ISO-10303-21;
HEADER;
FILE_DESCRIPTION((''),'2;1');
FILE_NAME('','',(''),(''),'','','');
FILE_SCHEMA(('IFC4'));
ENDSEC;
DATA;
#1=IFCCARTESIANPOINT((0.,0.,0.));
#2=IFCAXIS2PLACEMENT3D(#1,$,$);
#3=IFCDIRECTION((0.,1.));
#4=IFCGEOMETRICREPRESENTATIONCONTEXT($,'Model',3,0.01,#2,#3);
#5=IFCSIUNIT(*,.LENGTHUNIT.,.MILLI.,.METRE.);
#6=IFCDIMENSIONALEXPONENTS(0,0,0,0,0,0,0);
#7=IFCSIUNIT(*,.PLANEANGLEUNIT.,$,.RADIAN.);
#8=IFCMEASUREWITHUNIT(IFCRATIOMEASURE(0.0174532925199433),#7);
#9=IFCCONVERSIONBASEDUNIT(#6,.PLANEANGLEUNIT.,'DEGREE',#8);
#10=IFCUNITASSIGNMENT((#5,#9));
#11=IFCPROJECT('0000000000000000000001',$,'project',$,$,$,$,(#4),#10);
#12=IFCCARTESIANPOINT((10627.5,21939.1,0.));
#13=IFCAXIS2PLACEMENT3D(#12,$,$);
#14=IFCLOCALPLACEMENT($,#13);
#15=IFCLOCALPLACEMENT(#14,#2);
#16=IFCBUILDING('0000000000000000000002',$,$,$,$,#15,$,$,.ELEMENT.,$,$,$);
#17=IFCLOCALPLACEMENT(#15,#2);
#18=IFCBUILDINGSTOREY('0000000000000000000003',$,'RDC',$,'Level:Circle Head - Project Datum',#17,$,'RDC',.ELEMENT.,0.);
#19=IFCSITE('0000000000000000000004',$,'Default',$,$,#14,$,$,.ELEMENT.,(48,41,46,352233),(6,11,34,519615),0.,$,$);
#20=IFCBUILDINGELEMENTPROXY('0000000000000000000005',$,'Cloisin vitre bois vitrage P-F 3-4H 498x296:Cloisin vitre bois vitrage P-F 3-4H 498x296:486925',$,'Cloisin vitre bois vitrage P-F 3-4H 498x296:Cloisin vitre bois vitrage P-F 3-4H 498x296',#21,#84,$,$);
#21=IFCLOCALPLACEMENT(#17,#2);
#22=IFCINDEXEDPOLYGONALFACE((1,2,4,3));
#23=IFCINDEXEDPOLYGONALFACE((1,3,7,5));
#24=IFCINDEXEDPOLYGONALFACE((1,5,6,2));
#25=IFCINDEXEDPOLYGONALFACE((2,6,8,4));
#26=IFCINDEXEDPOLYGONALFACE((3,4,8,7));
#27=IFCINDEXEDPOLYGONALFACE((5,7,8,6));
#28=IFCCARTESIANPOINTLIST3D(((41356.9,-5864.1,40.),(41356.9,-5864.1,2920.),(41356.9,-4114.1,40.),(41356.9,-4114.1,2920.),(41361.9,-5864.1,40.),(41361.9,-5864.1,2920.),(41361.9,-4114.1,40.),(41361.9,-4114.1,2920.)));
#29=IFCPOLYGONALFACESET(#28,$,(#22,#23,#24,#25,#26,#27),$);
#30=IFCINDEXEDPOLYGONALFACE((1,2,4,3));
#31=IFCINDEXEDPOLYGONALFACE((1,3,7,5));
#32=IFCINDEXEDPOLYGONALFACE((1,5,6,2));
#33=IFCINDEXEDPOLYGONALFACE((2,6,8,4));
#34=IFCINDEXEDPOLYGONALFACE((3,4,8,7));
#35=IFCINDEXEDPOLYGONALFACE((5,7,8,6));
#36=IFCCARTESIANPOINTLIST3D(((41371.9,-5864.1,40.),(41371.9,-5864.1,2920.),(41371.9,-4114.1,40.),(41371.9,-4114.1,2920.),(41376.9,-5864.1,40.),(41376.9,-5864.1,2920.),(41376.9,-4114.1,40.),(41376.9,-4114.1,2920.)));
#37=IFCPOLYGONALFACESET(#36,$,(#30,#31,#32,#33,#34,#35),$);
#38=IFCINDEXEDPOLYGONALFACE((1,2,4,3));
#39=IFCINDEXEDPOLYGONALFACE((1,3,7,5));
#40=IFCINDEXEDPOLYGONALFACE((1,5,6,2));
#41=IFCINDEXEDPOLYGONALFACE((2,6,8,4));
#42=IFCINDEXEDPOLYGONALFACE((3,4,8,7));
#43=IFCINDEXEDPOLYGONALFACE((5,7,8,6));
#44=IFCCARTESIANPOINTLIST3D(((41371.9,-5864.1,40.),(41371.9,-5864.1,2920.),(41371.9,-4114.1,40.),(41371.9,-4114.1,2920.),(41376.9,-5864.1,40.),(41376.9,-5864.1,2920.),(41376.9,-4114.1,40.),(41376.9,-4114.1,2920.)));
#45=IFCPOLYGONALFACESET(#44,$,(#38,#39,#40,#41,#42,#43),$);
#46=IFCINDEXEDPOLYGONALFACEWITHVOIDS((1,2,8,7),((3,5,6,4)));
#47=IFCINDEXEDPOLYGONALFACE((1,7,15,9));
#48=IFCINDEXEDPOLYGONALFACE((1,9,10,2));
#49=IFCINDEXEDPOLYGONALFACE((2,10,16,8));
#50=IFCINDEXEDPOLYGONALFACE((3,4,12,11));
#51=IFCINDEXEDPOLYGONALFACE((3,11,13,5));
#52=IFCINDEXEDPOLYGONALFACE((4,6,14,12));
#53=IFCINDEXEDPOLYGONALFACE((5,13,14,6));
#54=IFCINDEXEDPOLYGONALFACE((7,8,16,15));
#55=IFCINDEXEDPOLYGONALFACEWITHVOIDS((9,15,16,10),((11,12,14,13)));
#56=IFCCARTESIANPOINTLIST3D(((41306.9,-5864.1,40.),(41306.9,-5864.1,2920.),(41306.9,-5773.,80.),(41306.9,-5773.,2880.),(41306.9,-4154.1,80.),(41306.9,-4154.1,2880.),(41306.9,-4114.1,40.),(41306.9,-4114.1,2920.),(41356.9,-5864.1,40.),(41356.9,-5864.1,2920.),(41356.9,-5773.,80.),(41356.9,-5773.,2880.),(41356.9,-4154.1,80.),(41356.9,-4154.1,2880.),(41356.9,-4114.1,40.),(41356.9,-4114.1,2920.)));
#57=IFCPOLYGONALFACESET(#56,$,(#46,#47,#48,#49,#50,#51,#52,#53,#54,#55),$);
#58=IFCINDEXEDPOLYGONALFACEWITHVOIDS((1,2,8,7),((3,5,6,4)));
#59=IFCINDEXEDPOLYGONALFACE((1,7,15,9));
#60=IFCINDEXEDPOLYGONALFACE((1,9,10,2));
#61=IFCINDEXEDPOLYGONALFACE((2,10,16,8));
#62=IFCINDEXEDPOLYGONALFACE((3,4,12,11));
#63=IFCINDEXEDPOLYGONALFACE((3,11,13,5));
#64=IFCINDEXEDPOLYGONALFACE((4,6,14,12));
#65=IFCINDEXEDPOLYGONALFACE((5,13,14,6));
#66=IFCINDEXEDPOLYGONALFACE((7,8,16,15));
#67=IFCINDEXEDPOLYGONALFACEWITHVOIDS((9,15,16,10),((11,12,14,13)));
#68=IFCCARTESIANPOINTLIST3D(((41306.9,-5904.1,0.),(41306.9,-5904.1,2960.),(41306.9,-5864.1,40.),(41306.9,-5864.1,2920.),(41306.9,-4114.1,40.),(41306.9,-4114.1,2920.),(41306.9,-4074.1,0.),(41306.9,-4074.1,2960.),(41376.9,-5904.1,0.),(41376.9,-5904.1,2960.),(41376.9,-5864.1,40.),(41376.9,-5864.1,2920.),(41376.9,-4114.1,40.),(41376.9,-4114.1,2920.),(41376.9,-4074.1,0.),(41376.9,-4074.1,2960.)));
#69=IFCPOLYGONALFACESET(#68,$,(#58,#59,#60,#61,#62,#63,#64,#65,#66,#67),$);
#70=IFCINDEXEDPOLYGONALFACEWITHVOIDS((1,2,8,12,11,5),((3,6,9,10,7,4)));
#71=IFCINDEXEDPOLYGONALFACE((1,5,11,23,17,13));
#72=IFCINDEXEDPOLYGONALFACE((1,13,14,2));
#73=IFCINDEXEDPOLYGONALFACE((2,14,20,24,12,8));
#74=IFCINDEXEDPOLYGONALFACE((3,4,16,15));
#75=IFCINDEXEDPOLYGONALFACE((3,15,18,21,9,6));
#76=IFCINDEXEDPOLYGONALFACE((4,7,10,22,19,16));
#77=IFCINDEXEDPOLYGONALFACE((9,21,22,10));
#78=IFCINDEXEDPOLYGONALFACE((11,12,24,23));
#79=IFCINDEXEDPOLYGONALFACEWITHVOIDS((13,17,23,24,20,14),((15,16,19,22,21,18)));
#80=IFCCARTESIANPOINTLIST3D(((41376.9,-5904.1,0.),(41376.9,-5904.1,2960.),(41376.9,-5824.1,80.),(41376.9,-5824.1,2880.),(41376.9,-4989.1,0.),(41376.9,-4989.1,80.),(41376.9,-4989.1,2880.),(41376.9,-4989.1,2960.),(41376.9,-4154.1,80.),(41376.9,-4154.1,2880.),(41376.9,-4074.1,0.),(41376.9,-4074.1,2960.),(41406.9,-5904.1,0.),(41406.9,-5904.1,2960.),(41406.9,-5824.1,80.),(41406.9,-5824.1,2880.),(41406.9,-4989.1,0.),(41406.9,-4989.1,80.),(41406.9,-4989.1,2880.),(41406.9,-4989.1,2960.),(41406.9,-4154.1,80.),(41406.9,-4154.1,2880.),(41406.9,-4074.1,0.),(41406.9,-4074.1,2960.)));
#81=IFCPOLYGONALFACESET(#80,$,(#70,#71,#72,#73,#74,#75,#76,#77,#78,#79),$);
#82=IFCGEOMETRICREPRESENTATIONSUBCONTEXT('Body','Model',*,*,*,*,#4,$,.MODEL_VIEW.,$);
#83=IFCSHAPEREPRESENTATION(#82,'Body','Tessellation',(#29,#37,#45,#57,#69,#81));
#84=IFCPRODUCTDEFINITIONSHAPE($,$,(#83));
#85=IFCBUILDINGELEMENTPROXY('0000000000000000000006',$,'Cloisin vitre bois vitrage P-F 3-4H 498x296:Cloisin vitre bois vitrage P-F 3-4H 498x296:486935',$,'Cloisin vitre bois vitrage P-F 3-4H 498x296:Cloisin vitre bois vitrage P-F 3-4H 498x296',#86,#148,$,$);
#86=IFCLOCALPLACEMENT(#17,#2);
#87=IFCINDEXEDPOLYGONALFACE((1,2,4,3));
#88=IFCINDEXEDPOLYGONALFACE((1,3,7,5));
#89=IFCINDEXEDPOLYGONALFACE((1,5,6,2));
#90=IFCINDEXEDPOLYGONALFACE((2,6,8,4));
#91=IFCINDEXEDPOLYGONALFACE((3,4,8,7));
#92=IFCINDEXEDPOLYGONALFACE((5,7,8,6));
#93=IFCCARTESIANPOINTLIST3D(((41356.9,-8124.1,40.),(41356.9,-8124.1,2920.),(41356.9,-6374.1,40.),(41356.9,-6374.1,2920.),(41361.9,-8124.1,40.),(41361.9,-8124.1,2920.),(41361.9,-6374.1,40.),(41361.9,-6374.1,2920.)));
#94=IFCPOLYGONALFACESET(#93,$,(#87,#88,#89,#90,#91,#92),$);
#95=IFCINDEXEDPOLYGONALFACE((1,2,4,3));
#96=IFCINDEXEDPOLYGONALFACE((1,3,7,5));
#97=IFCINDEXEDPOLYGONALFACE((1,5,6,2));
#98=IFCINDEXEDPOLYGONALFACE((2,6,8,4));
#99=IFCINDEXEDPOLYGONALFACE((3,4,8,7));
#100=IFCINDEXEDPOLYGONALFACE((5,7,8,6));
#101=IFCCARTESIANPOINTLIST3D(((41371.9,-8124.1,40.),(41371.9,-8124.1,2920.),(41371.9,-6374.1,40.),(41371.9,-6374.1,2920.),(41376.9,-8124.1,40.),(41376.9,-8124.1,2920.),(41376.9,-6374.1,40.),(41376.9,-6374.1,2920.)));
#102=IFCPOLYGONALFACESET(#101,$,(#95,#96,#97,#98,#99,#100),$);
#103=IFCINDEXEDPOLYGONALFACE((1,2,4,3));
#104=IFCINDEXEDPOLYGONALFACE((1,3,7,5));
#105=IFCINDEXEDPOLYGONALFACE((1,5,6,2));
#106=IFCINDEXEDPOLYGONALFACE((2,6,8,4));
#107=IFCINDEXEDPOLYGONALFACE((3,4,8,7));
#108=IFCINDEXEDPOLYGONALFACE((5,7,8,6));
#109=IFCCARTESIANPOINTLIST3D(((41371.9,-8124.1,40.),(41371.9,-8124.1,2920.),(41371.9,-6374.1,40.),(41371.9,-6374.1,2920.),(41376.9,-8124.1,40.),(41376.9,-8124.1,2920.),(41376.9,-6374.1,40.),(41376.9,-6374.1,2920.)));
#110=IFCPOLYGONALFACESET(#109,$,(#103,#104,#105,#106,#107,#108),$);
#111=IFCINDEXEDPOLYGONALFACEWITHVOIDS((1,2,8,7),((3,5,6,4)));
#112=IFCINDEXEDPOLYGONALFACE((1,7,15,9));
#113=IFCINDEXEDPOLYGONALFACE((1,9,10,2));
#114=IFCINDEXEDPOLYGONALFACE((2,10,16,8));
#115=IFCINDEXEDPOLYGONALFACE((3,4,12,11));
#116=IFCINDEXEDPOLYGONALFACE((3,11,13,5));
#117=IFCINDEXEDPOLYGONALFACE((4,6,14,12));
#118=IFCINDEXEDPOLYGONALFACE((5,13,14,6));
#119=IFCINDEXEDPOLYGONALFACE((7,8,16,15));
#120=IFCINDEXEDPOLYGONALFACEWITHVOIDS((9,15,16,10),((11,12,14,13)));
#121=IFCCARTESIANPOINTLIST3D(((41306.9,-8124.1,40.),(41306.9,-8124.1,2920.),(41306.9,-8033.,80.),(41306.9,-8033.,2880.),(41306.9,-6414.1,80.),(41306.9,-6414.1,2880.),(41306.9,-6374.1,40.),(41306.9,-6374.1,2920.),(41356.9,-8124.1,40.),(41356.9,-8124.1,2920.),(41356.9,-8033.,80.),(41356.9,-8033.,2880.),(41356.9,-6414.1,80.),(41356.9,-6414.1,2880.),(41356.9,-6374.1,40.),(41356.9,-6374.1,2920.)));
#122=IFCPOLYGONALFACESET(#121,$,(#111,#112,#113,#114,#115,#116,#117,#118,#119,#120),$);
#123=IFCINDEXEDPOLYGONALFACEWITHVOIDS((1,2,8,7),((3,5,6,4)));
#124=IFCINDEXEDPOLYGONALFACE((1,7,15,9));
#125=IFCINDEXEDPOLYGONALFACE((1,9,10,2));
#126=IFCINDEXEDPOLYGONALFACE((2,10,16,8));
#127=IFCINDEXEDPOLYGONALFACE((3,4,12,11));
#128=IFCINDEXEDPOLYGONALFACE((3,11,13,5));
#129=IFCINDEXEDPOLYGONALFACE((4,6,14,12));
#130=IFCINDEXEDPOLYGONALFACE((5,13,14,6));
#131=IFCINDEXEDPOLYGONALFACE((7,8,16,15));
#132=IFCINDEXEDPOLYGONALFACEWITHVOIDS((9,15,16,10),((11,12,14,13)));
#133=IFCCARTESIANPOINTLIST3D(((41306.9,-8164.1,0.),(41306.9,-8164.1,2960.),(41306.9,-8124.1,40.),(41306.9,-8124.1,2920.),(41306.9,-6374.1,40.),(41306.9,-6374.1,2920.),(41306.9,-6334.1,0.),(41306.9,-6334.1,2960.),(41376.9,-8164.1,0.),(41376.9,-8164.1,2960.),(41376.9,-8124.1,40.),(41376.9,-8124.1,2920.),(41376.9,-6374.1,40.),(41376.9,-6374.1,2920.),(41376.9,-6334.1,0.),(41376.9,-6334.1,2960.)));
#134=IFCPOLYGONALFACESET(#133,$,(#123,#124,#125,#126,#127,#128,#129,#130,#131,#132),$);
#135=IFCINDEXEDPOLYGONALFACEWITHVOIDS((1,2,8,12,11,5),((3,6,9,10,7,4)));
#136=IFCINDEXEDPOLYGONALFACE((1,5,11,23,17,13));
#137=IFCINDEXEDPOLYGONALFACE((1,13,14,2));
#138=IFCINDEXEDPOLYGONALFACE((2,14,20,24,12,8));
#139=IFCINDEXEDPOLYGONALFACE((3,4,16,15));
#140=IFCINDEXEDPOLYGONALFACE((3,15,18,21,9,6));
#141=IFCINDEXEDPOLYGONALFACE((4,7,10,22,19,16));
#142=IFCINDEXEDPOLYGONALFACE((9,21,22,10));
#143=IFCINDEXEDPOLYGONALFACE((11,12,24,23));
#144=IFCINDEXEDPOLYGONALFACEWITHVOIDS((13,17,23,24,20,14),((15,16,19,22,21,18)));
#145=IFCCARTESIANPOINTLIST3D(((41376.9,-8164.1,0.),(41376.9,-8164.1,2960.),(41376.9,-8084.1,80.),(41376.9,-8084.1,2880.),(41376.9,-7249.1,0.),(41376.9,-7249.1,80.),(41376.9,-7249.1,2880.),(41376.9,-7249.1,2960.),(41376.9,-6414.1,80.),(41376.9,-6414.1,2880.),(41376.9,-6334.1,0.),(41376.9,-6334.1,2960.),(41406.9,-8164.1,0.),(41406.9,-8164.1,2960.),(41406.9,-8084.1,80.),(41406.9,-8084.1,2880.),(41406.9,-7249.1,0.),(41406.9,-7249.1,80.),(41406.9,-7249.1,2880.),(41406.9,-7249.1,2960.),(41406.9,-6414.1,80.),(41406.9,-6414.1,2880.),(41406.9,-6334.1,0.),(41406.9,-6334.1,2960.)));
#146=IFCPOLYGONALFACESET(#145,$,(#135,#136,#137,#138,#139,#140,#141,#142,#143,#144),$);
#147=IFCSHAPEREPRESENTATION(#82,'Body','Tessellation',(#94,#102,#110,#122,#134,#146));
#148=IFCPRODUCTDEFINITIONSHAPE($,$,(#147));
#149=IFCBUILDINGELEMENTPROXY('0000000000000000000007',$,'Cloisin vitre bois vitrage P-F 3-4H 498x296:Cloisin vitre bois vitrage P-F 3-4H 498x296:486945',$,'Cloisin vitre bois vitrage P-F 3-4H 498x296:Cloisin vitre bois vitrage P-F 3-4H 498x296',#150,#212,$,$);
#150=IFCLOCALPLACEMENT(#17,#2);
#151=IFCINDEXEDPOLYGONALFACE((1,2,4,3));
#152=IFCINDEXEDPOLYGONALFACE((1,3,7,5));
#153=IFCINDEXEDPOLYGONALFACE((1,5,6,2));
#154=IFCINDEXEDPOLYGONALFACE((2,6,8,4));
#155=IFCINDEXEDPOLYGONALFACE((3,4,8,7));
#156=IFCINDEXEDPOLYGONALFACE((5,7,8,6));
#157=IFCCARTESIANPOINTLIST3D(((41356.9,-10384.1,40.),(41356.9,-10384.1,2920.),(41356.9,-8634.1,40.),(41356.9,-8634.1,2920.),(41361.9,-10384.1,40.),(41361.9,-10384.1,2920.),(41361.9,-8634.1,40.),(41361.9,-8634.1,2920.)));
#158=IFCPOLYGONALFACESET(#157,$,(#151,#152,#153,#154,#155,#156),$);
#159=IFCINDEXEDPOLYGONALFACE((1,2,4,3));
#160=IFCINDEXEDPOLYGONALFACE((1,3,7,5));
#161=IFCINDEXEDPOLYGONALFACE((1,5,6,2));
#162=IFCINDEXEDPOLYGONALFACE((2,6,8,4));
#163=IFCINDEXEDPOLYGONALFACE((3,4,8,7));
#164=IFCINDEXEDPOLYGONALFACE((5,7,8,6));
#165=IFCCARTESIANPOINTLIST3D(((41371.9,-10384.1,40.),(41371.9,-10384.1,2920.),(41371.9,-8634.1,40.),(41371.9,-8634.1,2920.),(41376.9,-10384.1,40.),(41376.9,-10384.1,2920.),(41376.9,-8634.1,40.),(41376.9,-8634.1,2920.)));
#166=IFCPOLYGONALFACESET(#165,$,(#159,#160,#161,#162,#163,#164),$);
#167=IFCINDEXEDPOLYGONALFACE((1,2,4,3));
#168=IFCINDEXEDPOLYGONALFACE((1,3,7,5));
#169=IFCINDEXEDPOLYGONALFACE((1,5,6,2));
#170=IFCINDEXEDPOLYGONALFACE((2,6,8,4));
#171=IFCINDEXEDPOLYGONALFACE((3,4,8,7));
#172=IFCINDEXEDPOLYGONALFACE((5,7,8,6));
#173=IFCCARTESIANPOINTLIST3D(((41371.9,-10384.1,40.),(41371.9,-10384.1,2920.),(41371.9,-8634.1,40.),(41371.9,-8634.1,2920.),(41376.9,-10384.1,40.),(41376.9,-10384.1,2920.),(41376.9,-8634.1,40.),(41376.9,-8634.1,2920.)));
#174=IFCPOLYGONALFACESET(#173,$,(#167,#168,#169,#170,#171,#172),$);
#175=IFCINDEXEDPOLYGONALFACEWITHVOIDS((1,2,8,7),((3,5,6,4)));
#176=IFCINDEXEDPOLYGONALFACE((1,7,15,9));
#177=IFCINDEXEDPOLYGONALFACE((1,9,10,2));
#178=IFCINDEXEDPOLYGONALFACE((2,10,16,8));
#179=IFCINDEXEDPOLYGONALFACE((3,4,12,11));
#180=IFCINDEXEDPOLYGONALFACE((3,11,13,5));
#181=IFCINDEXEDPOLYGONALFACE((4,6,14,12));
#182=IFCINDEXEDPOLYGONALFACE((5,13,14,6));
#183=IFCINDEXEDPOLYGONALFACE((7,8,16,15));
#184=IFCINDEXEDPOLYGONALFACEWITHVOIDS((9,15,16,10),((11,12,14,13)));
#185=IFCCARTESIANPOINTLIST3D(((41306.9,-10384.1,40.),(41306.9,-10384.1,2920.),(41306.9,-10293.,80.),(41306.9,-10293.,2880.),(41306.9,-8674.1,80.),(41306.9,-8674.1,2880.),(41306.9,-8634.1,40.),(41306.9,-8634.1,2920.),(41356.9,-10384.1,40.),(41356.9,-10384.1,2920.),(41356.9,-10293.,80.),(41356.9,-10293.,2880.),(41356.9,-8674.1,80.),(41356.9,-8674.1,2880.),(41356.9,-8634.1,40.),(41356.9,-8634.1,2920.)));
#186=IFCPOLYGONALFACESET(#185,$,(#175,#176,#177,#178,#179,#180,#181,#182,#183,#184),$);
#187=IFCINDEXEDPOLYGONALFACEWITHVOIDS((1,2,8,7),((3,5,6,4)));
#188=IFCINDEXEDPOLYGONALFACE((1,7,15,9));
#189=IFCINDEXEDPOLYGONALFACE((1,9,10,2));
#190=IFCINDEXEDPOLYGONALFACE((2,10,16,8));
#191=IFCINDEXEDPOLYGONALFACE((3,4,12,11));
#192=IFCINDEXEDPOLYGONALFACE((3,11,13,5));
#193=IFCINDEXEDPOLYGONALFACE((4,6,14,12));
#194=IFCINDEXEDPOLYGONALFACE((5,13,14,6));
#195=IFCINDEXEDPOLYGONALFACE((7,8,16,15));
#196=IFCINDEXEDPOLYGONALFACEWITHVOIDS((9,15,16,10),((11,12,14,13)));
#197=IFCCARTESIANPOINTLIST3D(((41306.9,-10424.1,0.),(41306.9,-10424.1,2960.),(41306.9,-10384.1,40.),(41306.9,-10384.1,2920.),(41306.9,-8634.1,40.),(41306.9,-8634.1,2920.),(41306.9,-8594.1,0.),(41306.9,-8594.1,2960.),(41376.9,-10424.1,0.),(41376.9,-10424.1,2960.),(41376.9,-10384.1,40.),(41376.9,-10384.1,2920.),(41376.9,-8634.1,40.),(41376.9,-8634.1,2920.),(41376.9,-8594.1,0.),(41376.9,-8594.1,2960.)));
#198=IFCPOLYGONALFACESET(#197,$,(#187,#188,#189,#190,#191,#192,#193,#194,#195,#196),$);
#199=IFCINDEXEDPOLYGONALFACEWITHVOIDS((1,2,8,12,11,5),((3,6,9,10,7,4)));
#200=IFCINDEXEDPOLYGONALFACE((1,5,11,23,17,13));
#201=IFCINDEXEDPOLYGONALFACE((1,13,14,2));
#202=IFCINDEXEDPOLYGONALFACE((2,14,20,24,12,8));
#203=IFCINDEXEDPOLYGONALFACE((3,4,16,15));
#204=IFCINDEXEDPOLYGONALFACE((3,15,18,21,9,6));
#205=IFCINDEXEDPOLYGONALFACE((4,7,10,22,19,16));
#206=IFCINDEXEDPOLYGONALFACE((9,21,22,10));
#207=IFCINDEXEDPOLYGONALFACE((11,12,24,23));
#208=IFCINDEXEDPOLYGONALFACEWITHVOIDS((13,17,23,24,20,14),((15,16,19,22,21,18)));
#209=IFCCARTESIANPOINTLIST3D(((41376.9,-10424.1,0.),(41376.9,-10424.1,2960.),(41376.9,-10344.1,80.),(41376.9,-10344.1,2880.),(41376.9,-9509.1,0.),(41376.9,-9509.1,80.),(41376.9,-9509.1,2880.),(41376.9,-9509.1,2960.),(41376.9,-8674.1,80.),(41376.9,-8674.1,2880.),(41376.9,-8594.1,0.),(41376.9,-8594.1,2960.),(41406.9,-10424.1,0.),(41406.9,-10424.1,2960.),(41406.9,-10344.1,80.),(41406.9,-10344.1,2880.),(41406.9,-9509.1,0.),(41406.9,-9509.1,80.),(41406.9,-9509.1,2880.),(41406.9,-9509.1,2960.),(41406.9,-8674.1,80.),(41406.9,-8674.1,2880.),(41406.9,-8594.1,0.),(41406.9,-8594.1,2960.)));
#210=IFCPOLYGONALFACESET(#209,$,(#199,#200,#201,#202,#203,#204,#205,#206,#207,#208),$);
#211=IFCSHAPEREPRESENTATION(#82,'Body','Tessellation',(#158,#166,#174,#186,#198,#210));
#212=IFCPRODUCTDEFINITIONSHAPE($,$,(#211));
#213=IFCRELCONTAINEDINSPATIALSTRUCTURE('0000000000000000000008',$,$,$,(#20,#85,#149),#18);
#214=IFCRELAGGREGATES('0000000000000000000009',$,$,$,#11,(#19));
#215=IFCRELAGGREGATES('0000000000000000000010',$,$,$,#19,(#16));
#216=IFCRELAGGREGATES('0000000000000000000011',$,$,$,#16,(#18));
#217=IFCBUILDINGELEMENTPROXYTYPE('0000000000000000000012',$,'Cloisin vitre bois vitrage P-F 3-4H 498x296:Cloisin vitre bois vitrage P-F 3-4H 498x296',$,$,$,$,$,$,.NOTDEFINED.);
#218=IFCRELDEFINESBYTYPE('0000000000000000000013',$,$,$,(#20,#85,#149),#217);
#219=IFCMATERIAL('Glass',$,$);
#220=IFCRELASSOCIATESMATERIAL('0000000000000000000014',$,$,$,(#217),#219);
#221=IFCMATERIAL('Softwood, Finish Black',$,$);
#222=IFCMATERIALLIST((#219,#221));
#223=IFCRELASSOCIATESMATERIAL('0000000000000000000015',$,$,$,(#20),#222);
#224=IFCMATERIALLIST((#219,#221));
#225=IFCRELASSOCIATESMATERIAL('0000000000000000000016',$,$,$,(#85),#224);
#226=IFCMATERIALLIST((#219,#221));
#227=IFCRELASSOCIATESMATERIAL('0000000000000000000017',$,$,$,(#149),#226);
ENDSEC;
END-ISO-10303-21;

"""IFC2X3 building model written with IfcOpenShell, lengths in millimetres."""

from ifc_helpers import new_model, entity, si_unit, converted_unit, direction, frame, frame_2d, origin, place, context, subcontext, project, spatial, polyline, rectangle, outline, extrude, source, transform, mapped, material, material_list, type_object, type_shapes, element, save


model = new_model("IFC2X3")

# Units and contexts
model_context = context("Model", 3, precision=0.01, world=origin(), true_north=direction((0.0, 1.0)))
body_context = subcontext(model_context, "Body", "Model", "MODEL_VIEW")
ifc_project = project(units=[si_unit("LENGTHUNIT", "METRE", prefix="MILLI"), converted_unit("PLANEANGLEUNIT", "DEGREE", entity("IfcRatioMeasure", 0.0174532925199433), si_unit("PLANEANGLEUNIT", "RADIAN"), dimensions=[0, 0, 0, 0, 0, 0, 0])], contexts=[model_context])

# Site, building, storey
site_placement = place(None, frame((10627.5, 21939.1, 0.0)))
site = spatial("IfcSite", under=ifc_project, at=site_placement, Name="Default", CompositionType="ELEMENT", RefLatitude=(48, 41, 46, 352233), RefLongitude=(6, 11, 34, 519615), RefElevation=0.0)
building_placement = place(site_placement, origin())
building = spatial("IfcBuilding", under=site, at=building_placement, CompositionType="ELEMENT")
storey_placement = place(building_placement, origin())
storey = spatial("IfcBuildingStorey", under=building, at=storey_placement, Name="RDC", ObjectType="Level:Circle Head - Project Datum", LongName="RDC", CompositionType="ELEMENT", Elevation=0.0)

# Building element proxies
ifc_material_1 = material(Name="Glass")
ifc_material_2 = material(Name="Softwood, Finish Black")
building_element_proxy_type_1 = type_object("IfcBuildingElementProxyType", Name="Cloisin vitre bois vitrage P-F 3-4H 498x296:Cloisin vitre bois vitrage P-F 3-4H 498x296", PredefinedType="NOTDEFINED", material=ifc_material_1)
shared_shape_1 = source(origin(), body_context, "Body", "SweptSolid", [
    extrude(rectangle(XDim=5.0, YDim=1750.0, at=frame_2d((0.0, 0.0), x_axis=(1.0, 0.0))), frame((0.0, -47.5, 40.0), z_axis=(0.0, 0.0, 1.0), x_axis=(0.0, 1.0, 0.0)), (0.0, 0.0, 1.0), 2880.0),
    extrude(rectangle(XDim=5.0, YDim=1750.0, at=frame_2d((0.0, 0.0), x_axis=(1.0, 0.0))), frame((0.0, -32.5, 40.0), z_axis=(0.0, 0.0, 1.0), x_axis=(0.0, 1.0, 0.0)), (0.0, 0.0, 1.0), 2880.0),
    extrude(rectangle(XDim=5.0, YDim=1750.0, at=frame_2d((0.0, 0.0), x_axis=(1.0, 0.0))), frame((0.0, -32.5, 40.0), z_axis=(0.0, 0.0, 1.0), x_axis=(0.0, 1.0, 0.0)), (0.0, 0.0, 1.0), 2880.0),
    extrude(outline(polyline([(-1440.0, -875.0), (1440.0, -875.0), (1440.0, 875.0), (-1440.0, 875.0), (-1440.0, -875.0)]), holes=[polyline([(1400.0, 835.0), (1400.0, -783.9), (-1400.0, -783.9), (-1400.0, 835.0), (1400.0, 835.0)])]), frame((0.0, -100.0, 1480.0), z_axis=(0.0, 1.0, 0.0), x_axis=(0.0, 0.0, -1.0)), (0.0, 0.0, 1.0), 50.0),
    extrude(outline(polyline([(-1480.0, -915.0), (1480.0, -915.0), (1480.0, 915.0), (-1480.0, 915.0), (-1480.0, -915.0)]), holes=[polyline([(-1440.0, -875.0), (-1440.0, 875.0), (1440.0, 875.0), (1440.0, -875.0), (-1440.0, -875.0)])]), frame((0.0, -100.0, 1480.0), z_axis=(0.0, 1.0, 0.0), x_axis=(0.0, 0.0, -1.0)), (0.0, 0.0, 1.0), 70.0),
    extrude(outline(polyline([(-1480.0, -915.0), (1480.0, -915.0), (1480.0, 0.0), (1480.0, 915.0), (-1480.0, 915.0), (-1480.0, 0.0), (-1480.0, -915.0)]), holes=[polyline([(1400.0, 0.0), (1400.0, -835.0), (-1400.0, -835.0), (-1400.0, 0.0), (-1400.0, 835.0), (1400.0, 835.0), (1400.0, 0.0)])]), frame((0.0, -30.0, 1480.0), z_axis=(0.0, 1.0, 0.0), x_axis=(0.0, 0.0, 1.0)), (0.0, 0.0, 1.0), 30.0),
])
type_shapes(building_element_proxy_type_1, [shared_shape_1])
ifc_material_list_1 = material_list([ifc_material_1, ifc_material_2])
proxy_1_placement = place(storey_placement, frame((41406.9, -4989.1, 0.0), z_axis=(0.0, 0.0, 1.0), x_axis=(0.0, -1.0, 0.0)))
element("IfcBuildingElementProxy", 1, at=proxy_1_placement, inside=storey, type_object=building_element_proxy_type_1, material=ifc_material_list_1, Name="Cloisin vitre bois vitrage P-F 3-4H 498x296:Cloisin vitre bois vitrage P-F 3-4H 498x296:486925", ObjectType="Cloisin vitre bois vitrage P-F 3-4H 498x296:Cloisin vitre bois vitrage P-F 3-4H 498x296", context=body_context, shape_type="MappedRepresentation", body=[
    mapped(shared_shape_1, transform((0.0, 0.0, 0.0), scale=1.0)),
])
ifc_material_list_2 = material_list([ifc_material_1, ifc_material_2])
proxy_2_placement = place(storey_placement, frame((41406.9, -7249.1, 0.0), z_axis=(0.0, 0.0, 1.0), x_axis=(0.0, -1.0, 0.0)))
element("IfcBuildingElementProxy", 2, at=proxy_2_placement, inside=storey, type_object=building_element_proxy_type_1, material=ifc_material_list_2, Name="Cloisin vitre bois vitrage P-F 3-4H 498x296:Cloisin vitre bois vitrage P-F 3-4H 498x296:486935", ObjectType="Cloisin vitre bois vitrage P-F 3-4H 498x296:Cloisin vitre bois vitrage P-F 3-4H 498x296", context=body_context, shape_type="MappedRepresentation", body=[
    mapped(shared_shape_1, transform((0.0, 0.0, 0.0), scale=1.0)),
])
ifc_material_list_3 = material_list([ifc_material_1, ifc_material_2])
proxy_3_placement = place(storey_placement, frame((41406.9, -9509.1, 0.0), z_axis=(0.0, 0.0, 1.0), x_axis=(0.0, -1.0, 0.0)))
element("IfcBuildingElementProxy", 3, at=proxy_3_placement, inside=storey, type_object=building_element_proxy_type_1, material=ifc_material_list_3, Name="Cloisin vitre bois vitrage P-F 3-4H 498x296:Cloisin vitre bois vitrage P-F 3-4H 498x296:486945", ObjectType="Cloisin vitre bois vitrage P-F 3-4H 498x296:Cloisin vitre bois vitrage P-F 3-4H 498x296", context=body_context, shape_type="MappedRepresentation", body=[
    mapped(shared_shape_1, transform((0.0, 0.0, 0.0), scale=1.0)),
])

save(model, "model.ifc")
